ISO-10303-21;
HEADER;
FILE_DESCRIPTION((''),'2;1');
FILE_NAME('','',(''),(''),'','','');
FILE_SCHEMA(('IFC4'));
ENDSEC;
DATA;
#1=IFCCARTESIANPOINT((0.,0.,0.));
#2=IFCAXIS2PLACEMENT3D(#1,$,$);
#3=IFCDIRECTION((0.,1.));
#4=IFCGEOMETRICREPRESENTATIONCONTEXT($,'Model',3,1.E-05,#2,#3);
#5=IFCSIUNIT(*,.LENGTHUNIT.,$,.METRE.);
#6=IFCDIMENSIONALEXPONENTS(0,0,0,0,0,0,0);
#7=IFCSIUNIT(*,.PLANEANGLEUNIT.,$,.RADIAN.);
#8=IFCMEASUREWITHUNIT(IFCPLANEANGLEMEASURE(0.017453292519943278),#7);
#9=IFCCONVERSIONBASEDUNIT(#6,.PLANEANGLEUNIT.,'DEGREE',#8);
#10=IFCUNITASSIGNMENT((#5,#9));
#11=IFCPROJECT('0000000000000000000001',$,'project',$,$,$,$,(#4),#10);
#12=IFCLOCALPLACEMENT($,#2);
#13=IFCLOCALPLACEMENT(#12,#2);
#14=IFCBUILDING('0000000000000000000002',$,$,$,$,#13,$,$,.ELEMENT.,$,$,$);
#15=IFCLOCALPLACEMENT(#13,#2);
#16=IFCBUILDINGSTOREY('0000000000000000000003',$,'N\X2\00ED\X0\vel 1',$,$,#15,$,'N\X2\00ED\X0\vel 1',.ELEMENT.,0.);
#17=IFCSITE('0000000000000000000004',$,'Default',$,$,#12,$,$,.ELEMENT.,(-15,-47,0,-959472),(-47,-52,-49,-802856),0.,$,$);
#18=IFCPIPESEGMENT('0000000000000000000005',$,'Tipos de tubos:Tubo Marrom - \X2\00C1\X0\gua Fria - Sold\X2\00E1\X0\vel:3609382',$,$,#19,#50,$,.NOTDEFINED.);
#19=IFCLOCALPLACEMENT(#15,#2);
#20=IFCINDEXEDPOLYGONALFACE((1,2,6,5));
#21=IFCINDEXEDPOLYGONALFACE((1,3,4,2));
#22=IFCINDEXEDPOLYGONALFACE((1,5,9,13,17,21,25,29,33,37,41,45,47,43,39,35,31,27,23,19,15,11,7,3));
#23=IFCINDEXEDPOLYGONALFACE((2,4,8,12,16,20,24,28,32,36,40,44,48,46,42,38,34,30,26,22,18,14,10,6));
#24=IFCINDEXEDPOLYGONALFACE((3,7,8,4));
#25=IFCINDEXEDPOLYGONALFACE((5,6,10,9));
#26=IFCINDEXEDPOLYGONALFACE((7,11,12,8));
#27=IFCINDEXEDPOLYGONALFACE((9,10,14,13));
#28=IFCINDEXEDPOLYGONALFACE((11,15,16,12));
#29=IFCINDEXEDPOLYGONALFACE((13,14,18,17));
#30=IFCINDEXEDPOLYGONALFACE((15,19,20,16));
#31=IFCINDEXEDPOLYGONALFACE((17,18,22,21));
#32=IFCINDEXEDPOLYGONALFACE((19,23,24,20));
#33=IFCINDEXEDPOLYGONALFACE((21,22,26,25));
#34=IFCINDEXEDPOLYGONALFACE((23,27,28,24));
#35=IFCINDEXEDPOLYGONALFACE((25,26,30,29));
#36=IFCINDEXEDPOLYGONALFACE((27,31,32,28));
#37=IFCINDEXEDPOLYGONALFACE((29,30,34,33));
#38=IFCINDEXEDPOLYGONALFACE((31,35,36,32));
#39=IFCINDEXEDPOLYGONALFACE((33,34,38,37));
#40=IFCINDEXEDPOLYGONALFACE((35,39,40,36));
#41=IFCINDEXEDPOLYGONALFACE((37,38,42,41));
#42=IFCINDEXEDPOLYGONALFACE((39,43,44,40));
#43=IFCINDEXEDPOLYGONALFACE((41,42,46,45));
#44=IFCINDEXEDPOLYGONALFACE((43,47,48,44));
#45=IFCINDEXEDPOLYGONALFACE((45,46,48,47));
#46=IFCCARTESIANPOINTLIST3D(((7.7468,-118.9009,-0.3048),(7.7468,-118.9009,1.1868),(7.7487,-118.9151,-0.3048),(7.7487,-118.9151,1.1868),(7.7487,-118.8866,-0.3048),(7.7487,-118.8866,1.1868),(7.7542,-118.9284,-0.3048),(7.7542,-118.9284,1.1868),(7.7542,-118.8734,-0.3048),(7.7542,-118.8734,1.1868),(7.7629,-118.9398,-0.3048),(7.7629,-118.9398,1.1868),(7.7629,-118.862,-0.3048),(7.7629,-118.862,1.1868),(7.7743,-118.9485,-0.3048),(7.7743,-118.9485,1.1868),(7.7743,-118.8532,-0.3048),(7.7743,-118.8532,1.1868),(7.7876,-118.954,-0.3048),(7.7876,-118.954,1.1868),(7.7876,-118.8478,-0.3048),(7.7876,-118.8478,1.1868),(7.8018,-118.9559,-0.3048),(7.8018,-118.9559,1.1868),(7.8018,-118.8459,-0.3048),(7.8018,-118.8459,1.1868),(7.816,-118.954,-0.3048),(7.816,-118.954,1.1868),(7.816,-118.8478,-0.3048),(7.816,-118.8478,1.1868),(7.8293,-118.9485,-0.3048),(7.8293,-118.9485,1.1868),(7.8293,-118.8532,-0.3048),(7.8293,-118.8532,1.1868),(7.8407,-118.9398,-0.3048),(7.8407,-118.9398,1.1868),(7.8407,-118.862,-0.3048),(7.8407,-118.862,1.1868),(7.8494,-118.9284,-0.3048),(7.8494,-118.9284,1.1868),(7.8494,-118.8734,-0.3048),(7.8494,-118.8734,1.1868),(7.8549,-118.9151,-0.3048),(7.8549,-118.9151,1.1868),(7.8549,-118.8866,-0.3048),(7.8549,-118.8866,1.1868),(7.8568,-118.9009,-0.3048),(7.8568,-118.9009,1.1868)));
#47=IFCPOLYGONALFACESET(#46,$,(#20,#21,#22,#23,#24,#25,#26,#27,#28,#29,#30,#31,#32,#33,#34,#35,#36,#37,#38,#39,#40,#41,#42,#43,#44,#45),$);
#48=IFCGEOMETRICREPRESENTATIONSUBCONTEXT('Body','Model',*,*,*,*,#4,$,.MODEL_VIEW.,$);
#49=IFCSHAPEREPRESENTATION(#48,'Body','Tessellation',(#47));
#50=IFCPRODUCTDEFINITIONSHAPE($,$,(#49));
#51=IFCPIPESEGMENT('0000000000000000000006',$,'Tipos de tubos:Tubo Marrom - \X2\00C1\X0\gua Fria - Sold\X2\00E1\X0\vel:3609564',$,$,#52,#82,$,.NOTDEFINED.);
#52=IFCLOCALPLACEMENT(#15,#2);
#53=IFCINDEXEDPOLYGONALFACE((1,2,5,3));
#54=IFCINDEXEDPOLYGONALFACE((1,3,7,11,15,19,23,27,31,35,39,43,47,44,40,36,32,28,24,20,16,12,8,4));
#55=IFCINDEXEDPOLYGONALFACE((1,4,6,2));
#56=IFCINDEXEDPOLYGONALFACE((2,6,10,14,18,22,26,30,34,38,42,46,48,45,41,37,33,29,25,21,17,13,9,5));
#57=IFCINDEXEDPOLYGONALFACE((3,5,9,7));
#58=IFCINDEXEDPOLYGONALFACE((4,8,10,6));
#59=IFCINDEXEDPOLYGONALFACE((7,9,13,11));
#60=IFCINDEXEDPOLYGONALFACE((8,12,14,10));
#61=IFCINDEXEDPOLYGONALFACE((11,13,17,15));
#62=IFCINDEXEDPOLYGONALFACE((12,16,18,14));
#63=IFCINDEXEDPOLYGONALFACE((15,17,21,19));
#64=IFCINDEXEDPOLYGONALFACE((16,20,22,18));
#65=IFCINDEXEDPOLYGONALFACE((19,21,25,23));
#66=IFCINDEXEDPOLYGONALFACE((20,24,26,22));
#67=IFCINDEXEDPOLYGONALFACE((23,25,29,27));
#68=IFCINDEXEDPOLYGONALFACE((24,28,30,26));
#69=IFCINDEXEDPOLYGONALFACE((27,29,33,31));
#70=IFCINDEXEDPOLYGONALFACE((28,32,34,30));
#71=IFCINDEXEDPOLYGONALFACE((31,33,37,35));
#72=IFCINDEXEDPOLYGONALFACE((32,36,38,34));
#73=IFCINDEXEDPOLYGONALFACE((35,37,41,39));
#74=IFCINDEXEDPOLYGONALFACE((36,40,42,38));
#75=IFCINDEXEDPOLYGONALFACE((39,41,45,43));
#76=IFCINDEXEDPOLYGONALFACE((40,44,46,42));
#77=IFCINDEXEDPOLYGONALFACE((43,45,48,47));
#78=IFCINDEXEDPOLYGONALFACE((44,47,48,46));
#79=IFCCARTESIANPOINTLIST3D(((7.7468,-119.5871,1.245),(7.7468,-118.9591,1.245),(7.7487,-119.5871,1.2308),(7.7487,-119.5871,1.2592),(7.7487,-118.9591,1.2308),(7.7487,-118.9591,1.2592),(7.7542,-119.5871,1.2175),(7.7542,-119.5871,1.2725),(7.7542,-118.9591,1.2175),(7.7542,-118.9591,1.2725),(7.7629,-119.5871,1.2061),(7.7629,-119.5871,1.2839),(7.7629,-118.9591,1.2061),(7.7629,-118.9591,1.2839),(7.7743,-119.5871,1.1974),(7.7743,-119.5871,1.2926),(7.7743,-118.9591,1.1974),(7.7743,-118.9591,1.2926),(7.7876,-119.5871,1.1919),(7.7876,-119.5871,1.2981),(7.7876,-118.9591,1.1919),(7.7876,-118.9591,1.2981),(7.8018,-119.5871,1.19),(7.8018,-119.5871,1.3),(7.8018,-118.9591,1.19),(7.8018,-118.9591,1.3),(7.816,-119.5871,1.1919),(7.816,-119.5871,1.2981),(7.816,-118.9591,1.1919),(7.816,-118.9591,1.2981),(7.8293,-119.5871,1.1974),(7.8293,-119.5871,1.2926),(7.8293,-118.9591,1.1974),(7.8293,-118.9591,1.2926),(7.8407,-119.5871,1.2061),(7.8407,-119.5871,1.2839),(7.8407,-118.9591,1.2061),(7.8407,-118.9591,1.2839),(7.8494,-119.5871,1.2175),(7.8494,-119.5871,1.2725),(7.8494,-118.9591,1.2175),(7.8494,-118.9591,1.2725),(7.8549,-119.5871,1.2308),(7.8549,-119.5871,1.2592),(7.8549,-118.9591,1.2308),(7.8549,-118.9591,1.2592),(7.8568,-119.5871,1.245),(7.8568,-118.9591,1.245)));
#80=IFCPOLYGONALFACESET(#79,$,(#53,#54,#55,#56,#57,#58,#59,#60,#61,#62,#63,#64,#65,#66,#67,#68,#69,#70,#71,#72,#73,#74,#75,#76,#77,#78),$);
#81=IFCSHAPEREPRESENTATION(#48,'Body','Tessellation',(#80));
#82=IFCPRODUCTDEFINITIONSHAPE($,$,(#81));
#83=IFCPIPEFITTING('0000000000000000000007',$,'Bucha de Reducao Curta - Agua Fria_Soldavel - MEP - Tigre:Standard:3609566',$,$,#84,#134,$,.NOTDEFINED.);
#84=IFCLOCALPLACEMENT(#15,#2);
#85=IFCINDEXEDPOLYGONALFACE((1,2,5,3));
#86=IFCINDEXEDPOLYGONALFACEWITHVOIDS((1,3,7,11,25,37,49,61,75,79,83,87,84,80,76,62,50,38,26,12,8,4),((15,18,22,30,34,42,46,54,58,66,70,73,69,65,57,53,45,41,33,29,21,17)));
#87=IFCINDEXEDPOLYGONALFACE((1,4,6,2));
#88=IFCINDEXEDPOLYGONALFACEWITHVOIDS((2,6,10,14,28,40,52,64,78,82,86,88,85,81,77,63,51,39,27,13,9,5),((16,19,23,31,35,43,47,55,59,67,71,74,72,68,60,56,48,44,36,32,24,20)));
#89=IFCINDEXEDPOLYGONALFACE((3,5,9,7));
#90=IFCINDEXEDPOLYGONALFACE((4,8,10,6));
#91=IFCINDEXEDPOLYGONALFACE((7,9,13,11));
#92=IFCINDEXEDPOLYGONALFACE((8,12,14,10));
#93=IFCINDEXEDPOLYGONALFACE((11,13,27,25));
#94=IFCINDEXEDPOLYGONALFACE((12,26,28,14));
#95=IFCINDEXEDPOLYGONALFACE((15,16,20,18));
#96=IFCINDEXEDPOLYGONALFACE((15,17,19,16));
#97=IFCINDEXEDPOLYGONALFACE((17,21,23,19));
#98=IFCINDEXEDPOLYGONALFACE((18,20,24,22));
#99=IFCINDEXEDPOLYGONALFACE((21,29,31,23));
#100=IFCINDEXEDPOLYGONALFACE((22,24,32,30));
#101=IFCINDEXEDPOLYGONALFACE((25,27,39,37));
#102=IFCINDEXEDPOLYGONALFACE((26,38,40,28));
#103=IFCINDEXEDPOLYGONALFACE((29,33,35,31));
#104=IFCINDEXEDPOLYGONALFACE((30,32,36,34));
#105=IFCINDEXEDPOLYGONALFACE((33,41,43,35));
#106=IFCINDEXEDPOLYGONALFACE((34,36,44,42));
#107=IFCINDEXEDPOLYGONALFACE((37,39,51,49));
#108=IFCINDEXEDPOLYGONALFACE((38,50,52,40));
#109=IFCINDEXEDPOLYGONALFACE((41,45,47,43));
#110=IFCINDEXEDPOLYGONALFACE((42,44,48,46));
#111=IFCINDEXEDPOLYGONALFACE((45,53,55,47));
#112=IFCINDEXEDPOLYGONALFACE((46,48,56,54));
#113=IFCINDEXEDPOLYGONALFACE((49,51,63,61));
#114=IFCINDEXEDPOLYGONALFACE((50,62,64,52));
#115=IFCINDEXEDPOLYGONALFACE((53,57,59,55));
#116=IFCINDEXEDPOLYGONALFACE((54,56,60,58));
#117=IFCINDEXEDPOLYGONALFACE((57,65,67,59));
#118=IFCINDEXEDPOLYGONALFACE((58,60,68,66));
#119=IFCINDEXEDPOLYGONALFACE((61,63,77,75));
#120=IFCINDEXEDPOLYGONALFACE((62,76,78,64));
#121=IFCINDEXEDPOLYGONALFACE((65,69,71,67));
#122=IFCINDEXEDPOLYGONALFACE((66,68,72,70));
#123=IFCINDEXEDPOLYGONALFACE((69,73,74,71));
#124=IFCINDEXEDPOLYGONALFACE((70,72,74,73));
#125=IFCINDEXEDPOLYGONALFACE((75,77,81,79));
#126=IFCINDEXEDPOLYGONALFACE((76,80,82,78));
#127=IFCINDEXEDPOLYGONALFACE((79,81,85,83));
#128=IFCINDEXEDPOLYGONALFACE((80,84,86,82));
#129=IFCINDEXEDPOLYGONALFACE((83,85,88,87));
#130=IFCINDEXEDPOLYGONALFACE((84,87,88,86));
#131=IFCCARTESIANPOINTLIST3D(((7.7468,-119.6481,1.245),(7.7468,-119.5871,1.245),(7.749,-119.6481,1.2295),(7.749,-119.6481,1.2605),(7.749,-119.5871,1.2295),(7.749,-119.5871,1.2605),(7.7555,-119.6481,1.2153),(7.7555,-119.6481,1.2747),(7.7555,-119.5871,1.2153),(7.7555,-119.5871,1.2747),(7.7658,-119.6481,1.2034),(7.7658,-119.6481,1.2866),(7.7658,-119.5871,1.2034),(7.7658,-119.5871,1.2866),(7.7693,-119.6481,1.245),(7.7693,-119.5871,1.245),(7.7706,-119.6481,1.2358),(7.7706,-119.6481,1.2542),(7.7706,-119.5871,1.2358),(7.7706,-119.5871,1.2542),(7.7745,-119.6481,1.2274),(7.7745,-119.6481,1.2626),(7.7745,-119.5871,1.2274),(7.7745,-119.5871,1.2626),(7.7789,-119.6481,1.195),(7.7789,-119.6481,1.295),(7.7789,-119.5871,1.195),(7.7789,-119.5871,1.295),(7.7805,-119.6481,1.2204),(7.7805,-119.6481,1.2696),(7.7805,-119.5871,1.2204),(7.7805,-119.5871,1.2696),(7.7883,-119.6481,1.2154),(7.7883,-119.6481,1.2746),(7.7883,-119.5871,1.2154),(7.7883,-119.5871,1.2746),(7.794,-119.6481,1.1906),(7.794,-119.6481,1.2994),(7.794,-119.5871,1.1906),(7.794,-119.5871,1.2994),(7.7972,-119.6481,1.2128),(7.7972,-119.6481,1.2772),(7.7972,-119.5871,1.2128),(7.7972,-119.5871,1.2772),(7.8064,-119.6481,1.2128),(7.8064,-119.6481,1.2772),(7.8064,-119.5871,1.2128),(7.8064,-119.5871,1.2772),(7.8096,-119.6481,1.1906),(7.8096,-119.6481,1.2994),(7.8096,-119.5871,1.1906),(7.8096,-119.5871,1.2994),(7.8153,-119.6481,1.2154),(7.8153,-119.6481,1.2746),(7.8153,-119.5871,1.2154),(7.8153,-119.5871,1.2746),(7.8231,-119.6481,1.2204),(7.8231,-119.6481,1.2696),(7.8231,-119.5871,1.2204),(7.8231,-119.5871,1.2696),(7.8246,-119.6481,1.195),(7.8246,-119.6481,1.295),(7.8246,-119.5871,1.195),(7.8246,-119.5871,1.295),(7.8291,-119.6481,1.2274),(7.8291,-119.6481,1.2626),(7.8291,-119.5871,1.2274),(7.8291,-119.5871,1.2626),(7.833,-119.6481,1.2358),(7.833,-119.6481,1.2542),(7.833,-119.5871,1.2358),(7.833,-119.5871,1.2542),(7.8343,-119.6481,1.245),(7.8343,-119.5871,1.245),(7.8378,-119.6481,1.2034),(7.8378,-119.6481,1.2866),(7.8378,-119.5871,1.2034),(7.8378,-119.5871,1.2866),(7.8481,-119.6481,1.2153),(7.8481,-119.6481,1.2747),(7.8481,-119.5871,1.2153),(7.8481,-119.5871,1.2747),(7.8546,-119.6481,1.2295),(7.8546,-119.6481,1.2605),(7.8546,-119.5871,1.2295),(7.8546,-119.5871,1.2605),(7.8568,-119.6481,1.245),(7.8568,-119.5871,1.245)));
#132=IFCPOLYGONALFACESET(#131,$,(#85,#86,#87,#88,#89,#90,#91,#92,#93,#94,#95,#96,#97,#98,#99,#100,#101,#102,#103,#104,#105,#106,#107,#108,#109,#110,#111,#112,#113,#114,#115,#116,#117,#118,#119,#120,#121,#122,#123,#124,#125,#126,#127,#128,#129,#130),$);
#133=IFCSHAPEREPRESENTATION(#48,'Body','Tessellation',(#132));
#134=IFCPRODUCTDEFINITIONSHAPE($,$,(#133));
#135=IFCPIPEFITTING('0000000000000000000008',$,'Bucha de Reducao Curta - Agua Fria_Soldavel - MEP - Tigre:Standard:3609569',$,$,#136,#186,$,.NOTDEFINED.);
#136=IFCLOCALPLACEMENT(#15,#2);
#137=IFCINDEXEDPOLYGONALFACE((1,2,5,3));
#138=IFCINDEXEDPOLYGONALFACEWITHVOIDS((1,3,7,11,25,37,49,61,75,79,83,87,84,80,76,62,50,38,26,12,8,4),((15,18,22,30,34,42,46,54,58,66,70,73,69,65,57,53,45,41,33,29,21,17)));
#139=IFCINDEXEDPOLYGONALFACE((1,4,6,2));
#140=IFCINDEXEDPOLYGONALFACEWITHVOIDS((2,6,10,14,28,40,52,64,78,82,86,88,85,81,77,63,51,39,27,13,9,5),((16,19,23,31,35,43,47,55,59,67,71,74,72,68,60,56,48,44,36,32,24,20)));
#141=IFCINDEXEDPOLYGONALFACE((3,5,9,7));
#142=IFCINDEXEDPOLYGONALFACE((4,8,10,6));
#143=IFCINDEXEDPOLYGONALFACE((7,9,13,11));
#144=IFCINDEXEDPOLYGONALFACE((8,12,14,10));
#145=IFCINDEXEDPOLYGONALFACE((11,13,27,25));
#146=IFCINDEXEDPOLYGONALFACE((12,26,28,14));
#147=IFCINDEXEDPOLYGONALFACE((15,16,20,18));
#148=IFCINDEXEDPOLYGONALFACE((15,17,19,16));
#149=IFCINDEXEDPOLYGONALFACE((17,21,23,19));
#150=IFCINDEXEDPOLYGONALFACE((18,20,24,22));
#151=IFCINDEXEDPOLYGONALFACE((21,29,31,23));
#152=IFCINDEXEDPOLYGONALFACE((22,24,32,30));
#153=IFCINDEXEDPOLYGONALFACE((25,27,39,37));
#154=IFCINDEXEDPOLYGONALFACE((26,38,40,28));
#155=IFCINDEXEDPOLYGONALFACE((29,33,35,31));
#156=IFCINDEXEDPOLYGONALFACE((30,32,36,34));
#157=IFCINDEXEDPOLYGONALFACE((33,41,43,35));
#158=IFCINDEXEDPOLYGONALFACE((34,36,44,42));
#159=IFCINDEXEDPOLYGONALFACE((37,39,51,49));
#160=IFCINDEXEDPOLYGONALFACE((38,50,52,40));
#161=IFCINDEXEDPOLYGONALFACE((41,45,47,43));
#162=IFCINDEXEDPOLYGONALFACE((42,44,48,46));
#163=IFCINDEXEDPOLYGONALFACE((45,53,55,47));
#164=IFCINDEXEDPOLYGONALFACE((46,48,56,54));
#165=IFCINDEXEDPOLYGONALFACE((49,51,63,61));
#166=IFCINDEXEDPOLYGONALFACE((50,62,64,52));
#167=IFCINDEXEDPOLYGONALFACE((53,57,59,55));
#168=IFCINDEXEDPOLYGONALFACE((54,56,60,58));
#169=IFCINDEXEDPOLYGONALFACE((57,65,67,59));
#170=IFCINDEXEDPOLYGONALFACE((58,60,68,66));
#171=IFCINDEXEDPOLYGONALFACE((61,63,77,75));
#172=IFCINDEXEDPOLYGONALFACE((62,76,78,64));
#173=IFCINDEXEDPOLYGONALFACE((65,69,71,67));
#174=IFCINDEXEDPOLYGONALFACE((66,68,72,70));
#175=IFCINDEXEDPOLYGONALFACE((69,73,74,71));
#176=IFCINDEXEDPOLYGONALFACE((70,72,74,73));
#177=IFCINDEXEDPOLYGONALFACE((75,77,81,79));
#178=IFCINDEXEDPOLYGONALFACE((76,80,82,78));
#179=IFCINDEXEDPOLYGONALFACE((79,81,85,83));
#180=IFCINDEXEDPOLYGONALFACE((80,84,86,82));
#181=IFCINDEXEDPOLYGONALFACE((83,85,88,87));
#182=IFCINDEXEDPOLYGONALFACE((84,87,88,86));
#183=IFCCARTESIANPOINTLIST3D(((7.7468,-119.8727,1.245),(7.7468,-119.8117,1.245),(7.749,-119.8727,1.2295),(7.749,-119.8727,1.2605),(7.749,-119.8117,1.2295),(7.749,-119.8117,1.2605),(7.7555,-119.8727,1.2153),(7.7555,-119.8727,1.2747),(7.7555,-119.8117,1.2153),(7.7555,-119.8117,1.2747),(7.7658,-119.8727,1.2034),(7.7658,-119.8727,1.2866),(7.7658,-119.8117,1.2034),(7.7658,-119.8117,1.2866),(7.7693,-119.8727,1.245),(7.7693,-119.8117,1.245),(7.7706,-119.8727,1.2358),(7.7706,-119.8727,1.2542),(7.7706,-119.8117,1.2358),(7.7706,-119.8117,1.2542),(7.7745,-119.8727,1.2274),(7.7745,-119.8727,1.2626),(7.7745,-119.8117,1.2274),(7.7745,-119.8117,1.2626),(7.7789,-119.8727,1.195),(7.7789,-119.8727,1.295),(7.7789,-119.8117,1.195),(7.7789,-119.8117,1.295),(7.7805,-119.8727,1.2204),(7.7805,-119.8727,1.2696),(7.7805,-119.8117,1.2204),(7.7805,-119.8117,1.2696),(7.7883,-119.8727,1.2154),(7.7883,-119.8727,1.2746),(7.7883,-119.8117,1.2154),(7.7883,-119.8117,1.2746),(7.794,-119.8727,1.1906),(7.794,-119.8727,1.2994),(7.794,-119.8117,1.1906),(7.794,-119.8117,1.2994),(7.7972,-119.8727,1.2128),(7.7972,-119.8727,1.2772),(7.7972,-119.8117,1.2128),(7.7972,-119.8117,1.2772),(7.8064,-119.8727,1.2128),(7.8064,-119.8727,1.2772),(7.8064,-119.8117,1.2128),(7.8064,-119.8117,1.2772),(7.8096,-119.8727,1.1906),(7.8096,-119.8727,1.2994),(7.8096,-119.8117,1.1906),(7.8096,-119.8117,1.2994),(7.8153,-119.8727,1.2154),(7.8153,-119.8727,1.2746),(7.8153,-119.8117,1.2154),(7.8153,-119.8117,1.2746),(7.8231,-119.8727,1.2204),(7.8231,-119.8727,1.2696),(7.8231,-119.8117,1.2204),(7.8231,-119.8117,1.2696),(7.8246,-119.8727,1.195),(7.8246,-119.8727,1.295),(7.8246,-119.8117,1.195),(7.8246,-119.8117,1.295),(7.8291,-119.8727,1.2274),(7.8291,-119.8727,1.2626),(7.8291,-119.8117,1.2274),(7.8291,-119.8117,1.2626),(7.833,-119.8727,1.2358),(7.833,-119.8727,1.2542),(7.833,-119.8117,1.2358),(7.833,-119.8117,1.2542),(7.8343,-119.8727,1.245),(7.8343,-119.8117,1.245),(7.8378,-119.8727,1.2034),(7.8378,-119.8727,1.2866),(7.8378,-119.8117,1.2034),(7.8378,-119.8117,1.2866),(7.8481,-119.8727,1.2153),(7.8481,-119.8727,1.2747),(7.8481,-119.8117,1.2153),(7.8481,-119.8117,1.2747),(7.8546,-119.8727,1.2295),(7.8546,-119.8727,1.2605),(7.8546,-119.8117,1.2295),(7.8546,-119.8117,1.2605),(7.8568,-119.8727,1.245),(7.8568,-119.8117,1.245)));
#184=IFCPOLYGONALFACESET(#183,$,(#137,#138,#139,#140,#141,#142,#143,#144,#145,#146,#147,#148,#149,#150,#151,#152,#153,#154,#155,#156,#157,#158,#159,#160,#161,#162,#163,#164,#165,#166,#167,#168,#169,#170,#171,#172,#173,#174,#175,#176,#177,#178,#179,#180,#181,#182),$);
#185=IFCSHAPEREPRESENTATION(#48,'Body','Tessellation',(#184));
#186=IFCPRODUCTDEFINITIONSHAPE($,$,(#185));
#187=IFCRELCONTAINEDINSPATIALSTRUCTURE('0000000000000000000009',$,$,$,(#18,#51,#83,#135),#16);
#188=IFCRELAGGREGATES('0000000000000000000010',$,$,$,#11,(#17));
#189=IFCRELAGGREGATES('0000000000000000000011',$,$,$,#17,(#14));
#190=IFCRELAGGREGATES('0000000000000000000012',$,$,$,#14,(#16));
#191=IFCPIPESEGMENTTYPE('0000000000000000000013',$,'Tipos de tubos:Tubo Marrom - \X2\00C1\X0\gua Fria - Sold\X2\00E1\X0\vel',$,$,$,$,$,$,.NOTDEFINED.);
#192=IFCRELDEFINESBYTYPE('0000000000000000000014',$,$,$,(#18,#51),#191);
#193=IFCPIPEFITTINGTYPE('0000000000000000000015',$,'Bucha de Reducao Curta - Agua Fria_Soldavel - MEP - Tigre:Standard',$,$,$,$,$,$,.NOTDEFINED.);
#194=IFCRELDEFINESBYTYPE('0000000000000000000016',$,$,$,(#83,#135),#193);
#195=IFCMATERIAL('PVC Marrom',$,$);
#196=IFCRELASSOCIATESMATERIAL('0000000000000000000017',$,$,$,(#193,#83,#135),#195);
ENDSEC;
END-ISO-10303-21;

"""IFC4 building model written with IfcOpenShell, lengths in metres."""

from ifc_helpers import new_model, entity, si_unit, converted_unit, direction, frame, origin, place, context, subcontext, project, spatial, arc, indexed_curve, outline, extrude, source, transform, mapped, material, type_object, type_shapes, element, save


model = new_model("IFC4")

# Units and contexts
model_context = context("Model", 3, precision=1e-05, world=origin(), true_north=direction((0.0, 1.0)))
body_context = subcontext(model_context, "Body", "Model", "MODEL_VIEW")
ifc_project = project(units=[si_unit("LENGTHUNIT", "METRE"), converted_unit("PLANEANGLEUNIT", "DEGREE", entity("IfcPlaneAngleMeasure", 0.017453292519943278), si_unit("PLANEANGLEUNIT", "RADIAN"), dimensions=[0, 0, 0, 0, 0, 0, 0])], contexts=[model_context])

# Site, building, storey
site_placement = place(None, origin())
site = spatial("IfcSite", under=ifc_project, at=site_placement, Name="Default", CompositionType="ELEMENT", RefLatitude=(-15, -47, 0, -959472), RefLongitude=(-47, -52, -49, -802856), RefElevation=0.0)
building_placement = place(site_placement, origin())
building = spatial("IfcBuilding", under=site, at=building_placement, CompositionType="ELEMENT")
storey_placement = place(building_placement, origin())
storey = spatial("IfcBuildingStorey", under=building, at=storey_placement, Name="Nível 1", LongName="Nível 1", CompositionType="ELEMENT", Elevation=0.0)

# Pipe segments
pipe_segment_type = type_object("IfcPipeSegmentType", Name="Tipos de tubos:Tubo Marrom - Água Fria - Soldável", PredefinedType="NOTDEFINED")
pipe_segment_1_placement = place(storey_placement, frame((7.7452, -118.9575, -0.3048)))
element("IfcPipeSegment", 1, at=pipe_segment_1_placement, inside=storey, type_object=pipe_segment_type, Name="Tipos de tubos:Tubo Marrom - Água Fria - Soldável:3609382", PredefinedType="NOTDEFINED", context=body_context, shape_type="SweptSolid", body=[
    extrude(outline(indexed_curve([(0.0, 0.055), (-0.0389, 0.0389), (-0.055, 0.0), (-0.0389, -0.0389), (0.0, -0.055), (0.0389, -0.0389), (0.055, 0.0), (0.0389, 0.0389)], segments=[arc(1, 2, 3), arc(3, 4, 5), arc(5, 6, 7), arc(7, 8, 1)], self_intersect=False)), frame((0.0566, 0.0566, 0.0)), (0.0, 0.0, 1.0), 1.4916),
])
pipe_segment_2_placement = place(storey_placement, frame((7.7452, -119.5871, 1.3016)))
element("IfcPipeSegment", 2, at=pipe_segment_2_placement, inside=storey, type_object=pipe_segment_type, Name="Tipos de tubos:Tubo Marrom - Água Fria - Soldável:3609564", PredefinedType="NOTDEFINED", context=body_context, shape_type="SweptSolid", body=[
    extrude(outline(indexed_curve([(0.055, 0.0), (0.0389, 0.0389), (0.0, 0.055), (-0.0389, 0.0389), (-0.055, 0.0), (-0.0389, -0.0389), (0.0, -0.055), (0.0389, -0.0389)], segments=[arc(1, 2, 3), arc(3, 4, 5), arc(5, 6, 7), arc(7, 8, 1)], self_intersect=False)), frame((0.0566, 0.0, -0.0566), z_axis=(0.0, 1.0, 0.0), x_axis=(-1.0, 0.0, 0.0)), (0.0, 0.0, 1.0), 0.628),
])

# Pipe fittings
ifc_material_1 = material(Name="PVC Marrom")
pipe_fitting_type_1 = type_object("IfcPipeFittingType", Name="Bucha de Reducao Curta - Agua Fria_Soldavel - MEP - Tigre:Standard", PredefinedType="NOTDEFINED", material=ifc_material_1)
shared_shape_1 = source(origin(), body_context, "Body", "SweptSolid", [
    extrude(outline(indexed_curve([(-0.055, 0.0), (0.0, -0.055), (0.055, 0.0), (0.0, 0.055)], segments=[arc(1, 2, 3), arc(3, 4, 1)], self_intersect=False), holes=[indexed_curve([(-0.0325, 0.0), (0.0, 0.0325), (0.0325, 0.0), (0.0, -0.0325)], segments=[arc(1, 2, 3), arc(3, 4, 1)], self_intersect=False)]), frame((0.0, 0.0, 0.0), z_axis=(1.0, 0.0, 0.0), x_axis=(0.0, 1.0, 0.0)), (0.0, 0.0, 1.0), 0.061),
])
type_shapes(pipe_fitting_type_1, [shared_shape_1])
for number, where, z_axis, x_axis, name in (
    (3, (7.8018, -119.5871, 1.245), (0.0, 0.0, 1.0), (0.0, -1.0, 0.0), "Bucha de Reducao Curta - Agua Fria_Soldavel - MEP - Tigre:Standard:3609566"),
    (4, (7.8018, -119.8727, 1.245), (0.0, 0.0, 1.0), (0.0, 1.0, 0.0), "Bucha de Reducao Curta - Agua Fria_Soldavel - MEP - Tigre:Standard:3609569"),
):
    element("IfcPipeFitting", number, at=place(storey_placement, frame(where, z_axis=z_axis, x_axis=x_axis)), inside=storey, type_object=pipe_fitting_type_1, material=ifc_material_1, Name=name, PredefinedType="NOTDEFINED", context=body_context, shape_type="MappedRepresentation", body=[
        mapped(shared_shape_1, transform((0.0, 0.0, 0.0), scale=1.0)),
    ])

save(model, "model.ifc")
